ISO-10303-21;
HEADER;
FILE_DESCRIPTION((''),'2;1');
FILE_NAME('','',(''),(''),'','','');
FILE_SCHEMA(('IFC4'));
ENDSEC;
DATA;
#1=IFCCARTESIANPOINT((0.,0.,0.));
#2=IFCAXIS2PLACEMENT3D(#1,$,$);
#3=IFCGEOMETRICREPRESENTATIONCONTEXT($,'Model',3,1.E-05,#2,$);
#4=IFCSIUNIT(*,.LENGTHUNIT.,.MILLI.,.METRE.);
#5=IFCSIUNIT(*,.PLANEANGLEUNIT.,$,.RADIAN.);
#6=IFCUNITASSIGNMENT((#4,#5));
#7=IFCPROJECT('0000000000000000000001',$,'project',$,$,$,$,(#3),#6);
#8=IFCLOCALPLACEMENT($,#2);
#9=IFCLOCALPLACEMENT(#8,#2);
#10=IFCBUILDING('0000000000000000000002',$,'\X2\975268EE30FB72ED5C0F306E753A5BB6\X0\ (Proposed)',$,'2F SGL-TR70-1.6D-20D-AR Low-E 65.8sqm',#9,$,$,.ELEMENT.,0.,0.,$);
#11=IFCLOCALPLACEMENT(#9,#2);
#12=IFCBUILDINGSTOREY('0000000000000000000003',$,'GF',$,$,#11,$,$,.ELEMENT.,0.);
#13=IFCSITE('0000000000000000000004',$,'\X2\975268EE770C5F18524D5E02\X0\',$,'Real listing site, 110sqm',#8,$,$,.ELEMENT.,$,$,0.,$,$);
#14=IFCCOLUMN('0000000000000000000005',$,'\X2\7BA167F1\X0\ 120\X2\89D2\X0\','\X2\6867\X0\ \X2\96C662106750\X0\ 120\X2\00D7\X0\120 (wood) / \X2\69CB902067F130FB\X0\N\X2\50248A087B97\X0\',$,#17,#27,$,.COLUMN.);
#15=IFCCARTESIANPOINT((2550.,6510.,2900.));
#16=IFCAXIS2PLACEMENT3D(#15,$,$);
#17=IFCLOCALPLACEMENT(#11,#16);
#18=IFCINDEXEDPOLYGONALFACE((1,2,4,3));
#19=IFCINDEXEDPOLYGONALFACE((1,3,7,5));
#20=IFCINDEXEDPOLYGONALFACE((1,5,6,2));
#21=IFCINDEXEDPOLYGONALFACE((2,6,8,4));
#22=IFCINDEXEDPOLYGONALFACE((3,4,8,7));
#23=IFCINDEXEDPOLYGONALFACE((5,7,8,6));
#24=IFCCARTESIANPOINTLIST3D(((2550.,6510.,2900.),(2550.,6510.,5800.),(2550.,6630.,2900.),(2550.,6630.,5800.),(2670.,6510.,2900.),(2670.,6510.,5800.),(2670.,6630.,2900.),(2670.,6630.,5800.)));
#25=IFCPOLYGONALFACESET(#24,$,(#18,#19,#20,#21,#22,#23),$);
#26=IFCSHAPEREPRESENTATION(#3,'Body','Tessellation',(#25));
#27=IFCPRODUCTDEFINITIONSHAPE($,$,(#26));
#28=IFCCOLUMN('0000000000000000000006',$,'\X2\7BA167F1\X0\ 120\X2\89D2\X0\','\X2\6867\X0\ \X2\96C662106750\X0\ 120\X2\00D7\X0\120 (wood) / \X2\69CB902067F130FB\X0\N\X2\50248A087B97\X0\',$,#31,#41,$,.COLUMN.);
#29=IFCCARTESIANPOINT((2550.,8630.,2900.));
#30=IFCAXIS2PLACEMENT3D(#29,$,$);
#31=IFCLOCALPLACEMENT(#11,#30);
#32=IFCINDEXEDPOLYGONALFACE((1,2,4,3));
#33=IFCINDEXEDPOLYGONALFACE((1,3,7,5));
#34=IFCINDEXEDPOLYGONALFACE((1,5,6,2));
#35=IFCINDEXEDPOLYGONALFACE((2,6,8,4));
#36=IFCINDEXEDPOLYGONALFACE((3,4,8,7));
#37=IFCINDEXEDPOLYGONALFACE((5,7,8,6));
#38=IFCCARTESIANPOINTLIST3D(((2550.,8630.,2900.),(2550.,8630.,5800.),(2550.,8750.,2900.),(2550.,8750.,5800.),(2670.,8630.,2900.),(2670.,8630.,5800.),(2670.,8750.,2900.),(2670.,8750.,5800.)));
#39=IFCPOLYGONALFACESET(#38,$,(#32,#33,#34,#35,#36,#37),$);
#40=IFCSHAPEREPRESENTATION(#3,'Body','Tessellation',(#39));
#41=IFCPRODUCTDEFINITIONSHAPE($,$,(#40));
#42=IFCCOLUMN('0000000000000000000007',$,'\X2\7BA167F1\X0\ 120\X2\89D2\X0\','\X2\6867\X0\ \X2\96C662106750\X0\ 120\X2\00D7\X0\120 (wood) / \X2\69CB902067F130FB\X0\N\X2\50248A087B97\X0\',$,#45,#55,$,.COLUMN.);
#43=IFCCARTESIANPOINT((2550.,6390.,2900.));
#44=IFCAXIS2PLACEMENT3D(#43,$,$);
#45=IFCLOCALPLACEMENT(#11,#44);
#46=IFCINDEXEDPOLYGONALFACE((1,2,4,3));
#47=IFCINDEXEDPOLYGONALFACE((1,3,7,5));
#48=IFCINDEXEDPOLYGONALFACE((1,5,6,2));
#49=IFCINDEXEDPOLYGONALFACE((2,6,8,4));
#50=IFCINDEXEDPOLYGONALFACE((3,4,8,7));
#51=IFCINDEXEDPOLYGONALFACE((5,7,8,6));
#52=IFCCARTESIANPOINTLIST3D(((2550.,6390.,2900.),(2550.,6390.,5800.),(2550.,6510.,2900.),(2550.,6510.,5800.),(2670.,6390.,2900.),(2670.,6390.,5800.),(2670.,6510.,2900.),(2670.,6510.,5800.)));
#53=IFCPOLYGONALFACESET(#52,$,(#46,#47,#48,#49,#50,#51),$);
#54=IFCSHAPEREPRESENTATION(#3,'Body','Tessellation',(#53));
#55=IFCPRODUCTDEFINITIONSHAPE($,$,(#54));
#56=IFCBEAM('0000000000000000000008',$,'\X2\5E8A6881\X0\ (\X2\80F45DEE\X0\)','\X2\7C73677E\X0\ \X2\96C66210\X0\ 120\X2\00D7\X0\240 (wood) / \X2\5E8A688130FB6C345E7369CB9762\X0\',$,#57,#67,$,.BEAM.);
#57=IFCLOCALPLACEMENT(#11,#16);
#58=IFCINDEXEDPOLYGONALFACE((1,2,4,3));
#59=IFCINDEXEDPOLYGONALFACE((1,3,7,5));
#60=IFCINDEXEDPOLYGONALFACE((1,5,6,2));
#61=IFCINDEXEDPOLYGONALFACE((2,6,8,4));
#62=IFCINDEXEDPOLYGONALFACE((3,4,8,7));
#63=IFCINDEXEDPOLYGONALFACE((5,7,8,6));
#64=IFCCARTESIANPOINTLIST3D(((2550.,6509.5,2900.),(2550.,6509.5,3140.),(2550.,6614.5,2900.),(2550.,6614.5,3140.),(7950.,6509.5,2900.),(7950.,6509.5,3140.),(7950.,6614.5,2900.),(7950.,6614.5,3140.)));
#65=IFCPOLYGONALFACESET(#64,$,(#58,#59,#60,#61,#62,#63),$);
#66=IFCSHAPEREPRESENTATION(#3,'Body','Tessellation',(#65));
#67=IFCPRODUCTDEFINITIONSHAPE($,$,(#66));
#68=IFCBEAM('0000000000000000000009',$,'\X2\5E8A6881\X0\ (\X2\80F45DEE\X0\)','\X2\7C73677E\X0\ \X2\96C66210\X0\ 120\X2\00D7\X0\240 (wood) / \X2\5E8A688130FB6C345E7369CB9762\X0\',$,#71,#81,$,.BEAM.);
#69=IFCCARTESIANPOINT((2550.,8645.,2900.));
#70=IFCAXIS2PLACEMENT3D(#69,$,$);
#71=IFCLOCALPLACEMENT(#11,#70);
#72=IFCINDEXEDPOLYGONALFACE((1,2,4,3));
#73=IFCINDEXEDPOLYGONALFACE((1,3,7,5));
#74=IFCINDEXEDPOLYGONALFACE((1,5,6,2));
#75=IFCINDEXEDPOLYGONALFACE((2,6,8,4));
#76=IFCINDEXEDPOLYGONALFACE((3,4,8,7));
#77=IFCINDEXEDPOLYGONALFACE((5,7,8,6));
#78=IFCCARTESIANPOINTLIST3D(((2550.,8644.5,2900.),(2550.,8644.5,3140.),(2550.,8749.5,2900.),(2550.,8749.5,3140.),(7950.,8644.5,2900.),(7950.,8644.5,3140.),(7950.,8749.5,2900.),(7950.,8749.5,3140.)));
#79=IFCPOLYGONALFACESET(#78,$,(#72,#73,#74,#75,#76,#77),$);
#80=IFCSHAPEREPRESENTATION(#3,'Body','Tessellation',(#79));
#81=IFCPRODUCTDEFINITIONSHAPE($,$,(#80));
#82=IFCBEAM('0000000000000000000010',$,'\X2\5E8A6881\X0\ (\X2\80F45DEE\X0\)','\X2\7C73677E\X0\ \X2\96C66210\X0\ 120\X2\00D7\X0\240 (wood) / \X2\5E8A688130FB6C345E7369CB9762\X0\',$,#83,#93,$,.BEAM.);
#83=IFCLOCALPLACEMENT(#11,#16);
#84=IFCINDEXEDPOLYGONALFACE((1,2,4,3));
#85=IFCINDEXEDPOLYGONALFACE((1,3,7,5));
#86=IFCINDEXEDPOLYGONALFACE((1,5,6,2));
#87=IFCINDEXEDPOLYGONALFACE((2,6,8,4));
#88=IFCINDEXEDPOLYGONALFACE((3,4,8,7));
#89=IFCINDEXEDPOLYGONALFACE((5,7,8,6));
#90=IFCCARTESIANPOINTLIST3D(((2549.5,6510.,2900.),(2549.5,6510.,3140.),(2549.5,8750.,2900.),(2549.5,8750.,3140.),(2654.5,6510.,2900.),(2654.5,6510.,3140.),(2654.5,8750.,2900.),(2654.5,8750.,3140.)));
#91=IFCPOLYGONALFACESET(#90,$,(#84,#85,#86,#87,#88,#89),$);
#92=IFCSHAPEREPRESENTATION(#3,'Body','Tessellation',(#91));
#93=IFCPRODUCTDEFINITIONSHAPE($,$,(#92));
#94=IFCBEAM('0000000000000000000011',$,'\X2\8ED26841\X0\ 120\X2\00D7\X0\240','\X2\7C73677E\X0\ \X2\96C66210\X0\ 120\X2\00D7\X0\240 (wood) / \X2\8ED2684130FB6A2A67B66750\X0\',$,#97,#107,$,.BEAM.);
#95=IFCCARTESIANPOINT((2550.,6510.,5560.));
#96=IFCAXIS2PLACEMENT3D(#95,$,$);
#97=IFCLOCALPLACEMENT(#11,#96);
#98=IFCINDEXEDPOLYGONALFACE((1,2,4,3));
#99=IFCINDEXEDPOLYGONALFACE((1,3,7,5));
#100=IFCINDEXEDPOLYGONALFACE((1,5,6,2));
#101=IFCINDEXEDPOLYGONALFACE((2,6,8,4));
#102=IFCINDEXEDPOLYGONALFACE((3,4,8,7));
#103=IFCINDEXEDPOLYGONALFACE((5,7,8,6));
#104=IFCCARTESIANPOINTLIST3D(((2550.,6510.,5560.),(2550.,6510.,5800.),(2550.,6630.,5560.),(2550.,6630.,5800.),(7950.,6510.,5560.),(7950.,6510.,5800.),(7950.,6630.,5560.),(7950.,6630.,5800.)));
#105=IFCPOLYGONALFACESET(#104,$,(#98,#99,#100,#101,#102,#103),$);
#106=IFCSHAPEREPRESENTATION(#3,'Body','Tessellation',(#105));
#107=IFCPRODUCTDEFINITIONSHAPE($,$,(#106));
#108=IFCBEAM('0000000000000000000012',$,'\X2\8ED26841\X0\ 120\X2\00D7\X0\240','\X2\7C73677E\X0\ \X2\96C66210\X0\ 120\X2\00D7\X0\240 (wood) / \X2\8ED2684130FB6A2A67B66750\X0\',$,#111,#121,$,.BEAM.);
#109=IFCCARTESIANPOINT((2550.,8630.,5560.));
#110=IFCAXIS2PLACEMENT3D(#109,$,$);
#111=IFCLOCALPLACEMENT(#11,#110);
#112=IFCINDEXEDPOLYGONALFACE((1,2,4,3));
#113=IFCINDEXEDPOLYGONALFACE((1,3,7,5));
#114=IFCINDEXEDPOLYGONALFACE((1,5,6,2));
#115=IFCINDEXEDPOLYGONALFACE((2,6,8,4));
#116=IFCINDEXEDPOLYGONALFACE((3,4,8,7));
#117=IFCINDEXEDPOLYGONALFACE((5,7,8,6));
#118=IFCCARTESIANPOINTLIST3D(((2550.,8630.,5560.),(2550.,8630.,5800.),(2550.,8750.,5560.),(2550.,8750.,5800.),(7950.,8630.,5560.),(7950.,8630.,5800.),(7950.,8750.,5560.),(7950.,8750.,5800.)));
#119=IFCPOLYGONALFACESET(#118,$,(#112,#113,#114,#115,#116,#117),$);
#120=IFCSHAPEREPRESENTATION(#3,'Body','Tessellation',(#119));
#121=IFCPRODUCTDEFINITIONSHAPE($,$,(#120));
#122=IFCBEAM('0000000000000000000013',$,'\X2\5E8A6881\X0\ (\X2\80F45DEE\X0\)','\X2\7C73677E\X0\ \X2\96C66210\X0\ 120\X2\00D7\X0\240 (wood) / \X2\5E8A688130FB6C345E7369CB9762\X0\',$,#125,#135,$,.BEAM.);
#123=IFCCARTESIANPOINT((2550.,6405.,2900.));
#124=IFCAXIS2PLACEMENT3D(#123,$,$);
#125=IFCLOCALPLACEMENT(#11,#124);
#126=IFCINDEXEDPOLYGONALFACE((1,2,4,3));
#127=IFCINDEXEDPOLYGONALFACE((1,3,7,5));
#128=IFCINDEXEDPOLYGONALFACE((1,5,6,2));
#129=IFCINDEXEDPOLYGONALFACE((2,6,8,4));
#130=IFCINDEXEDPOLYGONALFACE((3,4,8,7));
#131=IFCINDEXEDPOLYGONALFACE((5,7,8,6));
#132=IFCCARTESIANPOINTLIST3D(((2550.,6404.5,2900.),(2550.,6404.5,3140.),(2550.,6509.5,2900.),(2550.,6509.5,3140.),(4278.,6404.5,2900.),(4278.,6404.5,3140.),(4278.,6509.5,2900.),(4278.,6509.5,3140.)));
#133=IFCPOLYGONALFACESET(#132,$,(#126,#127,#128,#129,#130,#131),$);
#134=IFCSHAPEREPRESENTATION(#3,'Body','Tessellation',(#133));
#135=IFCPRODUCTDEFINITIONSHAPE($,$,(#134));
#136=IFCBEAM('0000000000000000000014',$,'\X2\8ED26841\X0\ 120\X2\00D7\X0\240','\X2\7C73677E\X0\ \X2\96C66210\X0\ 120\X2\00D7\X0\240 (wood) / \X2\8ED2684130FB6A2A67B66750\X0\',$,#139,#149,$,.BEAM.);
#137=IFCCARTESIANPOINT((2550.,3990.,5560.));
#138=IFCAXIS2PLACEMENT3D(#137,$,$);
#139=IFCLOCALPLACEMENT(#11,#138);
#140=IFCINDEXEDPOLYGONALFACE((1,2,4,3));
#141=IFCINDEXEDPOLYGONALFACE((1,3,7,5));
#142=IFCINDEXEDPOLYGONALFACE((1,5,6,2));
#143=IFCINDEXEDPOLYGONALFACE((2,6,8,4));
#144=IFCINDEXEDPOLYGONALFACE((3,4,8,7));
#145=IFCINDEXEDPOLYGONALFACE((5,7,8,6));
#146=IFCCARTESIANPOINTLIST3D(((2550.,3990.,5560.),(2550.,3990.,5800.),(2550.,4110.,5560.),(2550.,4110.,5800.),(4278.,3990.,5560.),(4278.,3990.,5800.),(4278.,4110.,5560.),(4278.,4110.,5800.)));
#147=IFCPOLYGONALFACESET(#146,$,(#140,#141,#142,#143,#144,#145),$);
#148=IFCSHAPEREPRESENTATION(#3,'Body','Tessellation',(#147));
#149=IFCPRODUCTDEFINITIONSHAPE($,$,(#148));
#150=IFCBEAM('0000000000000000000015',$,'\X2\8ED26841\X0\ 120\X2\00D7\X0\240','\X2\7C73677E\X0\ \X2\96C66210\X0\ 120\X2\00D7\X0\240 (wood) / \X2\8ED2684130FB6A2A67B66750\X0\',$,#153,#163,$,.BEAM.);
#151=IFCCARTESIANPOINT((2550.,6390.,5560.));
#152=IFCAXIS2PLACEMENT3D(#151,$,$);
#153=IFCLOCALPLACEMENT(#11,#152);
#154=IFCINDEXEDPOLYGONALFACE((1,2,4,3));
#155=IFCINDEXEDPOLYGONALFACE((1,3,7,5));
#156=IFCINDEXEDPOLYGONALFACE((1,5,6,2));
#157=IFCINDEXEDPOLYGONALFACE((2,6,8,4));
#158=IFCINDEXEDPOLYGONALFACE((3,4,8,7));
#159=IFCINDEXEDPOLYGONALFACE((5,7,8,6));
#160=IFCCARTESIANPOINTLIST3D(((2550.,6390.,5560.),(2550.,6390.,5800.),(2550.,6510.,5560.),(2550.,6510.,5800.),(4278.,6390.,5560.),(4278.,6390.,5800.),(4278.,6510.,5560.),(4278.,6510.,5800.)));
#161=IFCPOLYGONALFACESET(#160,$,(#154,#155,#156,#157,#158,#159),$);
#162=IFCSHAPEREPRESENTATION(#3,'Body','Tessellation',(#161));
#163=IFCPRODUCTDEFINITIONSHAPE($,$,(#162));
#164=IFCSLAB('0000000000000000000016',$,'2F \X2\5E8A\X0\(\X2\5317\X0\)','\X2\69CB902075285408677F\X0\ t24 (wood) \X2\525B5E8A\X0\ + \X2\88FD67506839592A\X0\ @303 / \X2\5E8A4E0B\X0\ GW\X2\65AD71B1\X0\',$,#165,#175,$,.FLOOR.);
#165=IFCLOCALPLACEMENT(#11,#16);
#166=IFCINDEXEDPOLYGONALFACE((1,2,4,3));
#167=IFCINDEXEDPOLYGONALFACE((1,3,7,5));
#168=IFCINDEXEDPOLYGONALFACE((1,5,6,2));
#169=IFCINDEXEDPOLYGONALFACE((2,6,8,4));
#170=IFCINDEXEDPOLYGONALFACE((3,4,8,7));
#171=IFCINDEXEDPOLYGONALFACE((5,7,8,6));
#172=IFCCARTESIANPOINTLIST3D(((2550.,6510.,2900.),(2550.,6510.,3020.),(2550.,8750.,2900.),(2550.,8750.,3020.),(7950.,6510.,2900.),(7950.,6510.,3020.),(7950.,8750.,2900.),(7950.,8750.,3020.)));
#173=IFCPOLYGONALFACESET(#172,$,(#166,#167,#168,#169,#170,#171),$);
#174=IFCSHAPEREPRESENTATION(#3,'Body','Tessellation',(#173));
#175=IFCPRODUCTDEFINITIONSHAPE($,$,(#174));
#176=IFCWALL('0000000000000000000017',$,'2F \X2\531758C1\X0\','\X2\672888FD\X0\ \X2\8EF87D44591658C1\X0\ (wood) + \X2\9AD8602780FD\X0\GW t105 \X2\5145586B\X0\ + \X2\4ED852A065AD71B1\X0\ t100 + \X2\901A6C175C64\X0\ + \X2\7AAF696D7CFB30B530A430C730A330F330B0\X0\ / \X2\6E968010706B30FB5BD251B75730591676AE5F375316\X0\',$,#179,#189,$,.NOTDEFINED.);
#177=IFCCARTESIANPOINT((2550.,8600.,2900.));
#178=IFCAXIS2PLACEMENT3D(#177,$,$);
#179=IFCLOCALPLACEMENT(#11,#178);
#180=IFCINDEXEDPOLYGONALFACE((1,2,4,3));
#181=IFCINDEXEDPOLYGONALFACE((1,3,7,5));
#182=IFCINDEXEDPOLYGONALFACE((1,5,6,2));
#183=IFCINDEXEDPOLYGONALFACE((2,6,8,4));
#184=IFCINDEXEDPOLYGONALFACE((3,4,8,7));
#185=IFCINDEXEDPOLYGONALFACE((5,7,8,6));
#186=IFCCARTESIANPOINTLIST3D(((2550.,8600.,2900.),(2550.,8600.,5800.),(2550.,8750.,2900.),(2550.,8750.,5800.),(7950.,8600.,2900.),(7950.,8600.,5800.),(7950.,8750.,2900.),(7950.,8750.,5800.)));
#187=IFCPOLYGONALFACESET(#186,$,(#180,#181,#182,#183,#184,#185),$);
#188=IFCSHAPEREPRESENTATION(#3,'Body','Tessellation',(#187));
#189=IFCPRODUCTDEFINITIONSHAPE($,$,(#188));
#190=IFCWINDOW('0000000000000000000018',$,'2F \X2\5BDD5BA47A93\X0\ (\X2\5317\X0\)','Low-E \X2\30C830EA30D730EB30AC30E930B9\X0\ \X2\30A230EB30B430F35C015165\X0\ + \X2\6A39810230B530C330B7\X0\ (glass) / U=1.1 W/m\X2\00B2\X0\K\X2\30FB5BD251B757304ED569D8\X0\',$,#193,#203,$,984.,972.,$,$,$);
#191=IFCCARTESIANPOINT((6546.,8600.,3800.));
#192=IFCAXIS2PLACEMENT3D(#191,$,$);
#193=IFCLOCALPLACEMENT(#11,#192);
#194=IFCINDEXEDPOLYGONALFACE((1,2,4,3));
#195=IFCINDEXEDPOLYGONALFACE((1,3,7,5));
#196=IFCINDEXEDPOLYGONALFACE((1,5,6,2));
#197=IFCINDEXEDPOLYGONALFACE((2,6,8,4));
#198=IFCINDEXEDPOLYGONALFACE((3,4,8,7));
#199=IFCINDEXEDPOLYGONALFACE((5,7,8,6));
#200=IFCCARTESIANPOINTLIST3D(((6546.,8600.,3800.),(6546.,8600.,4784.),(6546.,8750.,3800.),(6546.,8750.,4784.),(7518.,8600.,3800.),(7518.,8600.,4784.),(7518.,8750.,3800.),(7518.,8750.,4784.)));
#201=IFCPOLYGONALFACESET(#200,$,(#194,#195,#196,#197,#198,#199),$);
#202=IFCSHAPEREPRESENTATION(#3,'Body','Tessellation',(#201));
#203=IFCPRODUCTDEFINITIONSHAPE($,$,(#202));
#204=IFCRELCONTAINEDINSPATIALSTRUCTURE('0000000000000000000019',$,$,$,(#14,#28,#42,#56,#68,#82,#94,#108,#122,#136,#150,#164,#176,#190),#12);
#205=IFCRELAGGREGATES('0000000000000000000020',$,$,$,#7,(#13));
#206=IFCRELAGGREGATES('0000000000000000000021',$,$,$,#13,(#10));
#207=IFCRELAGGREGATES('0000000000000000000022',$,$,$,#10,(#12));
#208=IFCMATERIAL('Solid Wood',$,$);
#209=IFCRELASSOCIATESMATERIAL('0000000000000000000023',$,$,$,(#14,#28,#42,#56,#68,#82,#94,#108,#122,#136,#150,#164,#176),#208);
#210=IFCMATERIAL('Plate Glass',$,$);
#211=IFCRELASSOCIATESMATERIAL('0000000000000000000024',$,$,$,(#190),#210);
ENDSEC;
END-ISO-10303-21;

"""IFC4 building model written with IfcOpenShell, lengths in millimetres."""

from ifc_helpers import new_model, si_unit, frame, frame_2d, origin, place, context, project, spatial, rectangle, extrude, material, element, fill, save


model = new_model("IFC4")

# Units and contexts
model_context = context("Model", 3, precision=1e-05, world=origin())
ifc_project = project(units=[si_unit("LENGTHUNIT", "METRE", prefix="MILLI"), si_unit("PLANEANGLEUNIT", "RADIAN")], contexts=[model_context])

# Site, building, storey
site_placement = place(None, origin())
site = spatial("IfcSite", under=ifc_project, at=site_placement, Name="青森県弘前市", ObjectType="Real listing site, 110sqm", CompositionType="ELEMENT", RefElevation=0.0)
building_placement = place(site_placement, origin())
building = spatial("IfcBuilding", under=site, at=building_placement, Name="青森・狭小の町家 (Proposed)", ObjectType="2F SGL-TR70-1.6D-20D-AR Low-E 65.8sqm", CompositionType="ELEMENT", ElevationOfRefHeight=0.0, ElevationOfTerrain=0.0)
storey_placement = place(building_placement, origin())
storey = spatial("IfcBuildingStorey", under=building, at=storey_placement, Name="GF", CompositionType="ELEMENT", Elevation=0.0)

# Columns
ifc_material_1 = material(Name="Solid Wood")
column_1_placement = place(storey_placement, frame((2550.0, 6510.0, 2900.0)))
element("IfcColumn", 1, at=column_1_placement, inside=storey, material=ifc_material_1, Name="管柱 120角", Description="桧 集成材 120×120 (wood) / 構造柱・N値計算", PredefinedType="COLUMN", context=model_context, shape_type="SweptSolid", body=[
    extrude(rectangle(XDim=120.0, YDim=120.0, at=frame_2d((60.0, 60.0))), frame((2550.0, 6510.0, 2900.0)), (0.0, 0.0, 1.0), 2900.0),
])
column_2_placement = place(storey_placement, frame((2550.0, 8630.0, 2900.0)))
element("IfcColumn", 2, at=column_2_placement, inside=storey, material=ifc_material_1, Name="管柱 120角", Description="桧 集成材 120×120 (wood) / 構造柱・N値計算", PredefinedType="COLUMN", context=model_context, shape_type="SweptSolid", body=[
    extrude(rectangle(XDim=120.0, YDim=120.0, at=frame_2d((60.0, 60.0))), frame((2550.0, 8630.0, 2900.0)), (0.0, 0.0, 1.0), 2900.0),
])
column_3_placement = place(storey_placement, frame((2550.0, 6390.0, 2900.0)))
element("IfcColumn", 3, at=column_3_placement, inside=storey, material=ifc_material_1, Name="管柱 120角", Description="桧 集成材 120×120 (wood) / 構造柱・N値計算", PredefinedType="COLUMN", context=model_context, shape_type="SweptSolid", body=[
    extrude(rectangle(XDim=120.0, YDim=120.0, at=frame_2d((60.0, 60.0))), frame((2550.0, 6390.0, 2900.0)), (0.0, 0.0, 1.0), 2900.0),
])

# Beams
beam_1_placement = place(storey_placement, frame((2550.0, 6510.0, 2900.0)))
element("IfcBeam", 4, at=beam_1_placement, inside=storey, material=ifc_material_1, Name="床梁 (胴差)", Description="米松 集成 120×240 (wood) / 床梁・水平構面", PredefinedType="BEAM", context=model_context, shape_type="SweptSolid", body=[
    extrude(rectangle(XDim=5400.0, YDim=105.0, at=frame_2d((2700.0, 52.0))), frame((2550.0, 6510.0, 2900.0)), (0.0, 0.0, 1.0), 240.0),
])
beam_2_placement = place(storey_placement, frame((2550.0, 8645.0, 2900.0)))
element("IfcBeam", 5, at=beam_2_placement, inside=storey, material=ifc_material_1, Name="床梁 (胴差)", Description="米松 集成 120×240 (wood) / 床梁・水平構面", PredefinedType="BEAM", context=model_context, shape_type="SweptSolid", body=[
    extrude(rectangle(XDim=5400.0, YDim=105.0, at=frame_2d((2700.0, 52.0))), frame((2550.0, 8645.0, 2900.0)), (0.0, 0.0, 1.0), 240.0),
])
beam_3_placement = place(storey_placement, frame((2550.0, 6510.0, 2900.0)))
element("IfcBeam", 6, at=beam_3_placement, inside=storey, material=ifc_material_1, Name="床梁 (胴差)", Description="米松 集成 120×240 (wood) / 床梁・水平構面", PredefinedType="BEAM", context=model_context, shape_type="SweptSolid", body=[
    extrude(rectangle(XDim=105.0, YDim=2240.0, at=frame_2d((52.0, 1120.0))), frame((2550.0, 6510.0, 2900.0)), (0.0, 0.0, 1.0), 240.0),
])
beam_4_placement = place(storey_placement, frame((2550.0, 6510.0, 5560.0)))
element("IfcBeam", 7, at=beam_4_placement, inside=storey, material=ifc_material_1, Name="軒桁 120×240", Description="米松 集成 120×240 (wood) / 軒桁・横架材", PredefinedType="BEAM", context=model_context, shape_type="SweptSolid", body=[
    extrude(rectangle(XDim=5400.0, YDim=120.0, at=frame_2d((2700.0, 60.0))), frame((2550.0, 6510.0, 5560.0)), (0.0, 0.0, 1.0), 240.0),
])
beam_5_placement = place(storey_placement, frame((2550.0, 8630.0, 5560.0)))
element("IfcBeam", 8, at=beam_5_placement, inside=storey, material=ifc_material_1, Name="軒桁 120×240", Description="米松 集成 120×240 (wood) / 軒桁・横架材", PredefinedType="BEAM", context=model_context, shape_type="SweptSolid", body=[
    extrude(rectangle(XDim=5400.0, YDim=120.0, at=frame_2d((2700.0, 60.0))), frame((2550.0, 8630.0, 5560.0)), (0.0, 0.0, 1.0), 240.0),
])
beam_6_placement = place(storey_placement, frame((2550.0, 6405.0, 2900.0)))
element("IfcBeam", 9, at=beam_6_placement, inside=storey, material=ifc_material_1, Name="床梁 (胴差)", Description="米松 集成 120×240 (wood) / 床梁・水平構面", PredefinedType="BEAM", context=model_context, shape_type="SweptSolid", body=[
    extrude(rectangle(XDim=1728.0, YDim=105.0, at=frame_2d((864.0, 52.0))), frame((2550.0, 6405.0, 2900.0)), (0.0, 0.0, 1.0), 240.0),
])
beam_7_placement = place(storey_placement, frame((2550.0, 3990.0, 5560.0)))
element("IfcBeam", 10, at=beam_7_placement, inside=storey, material=ifc_material_1, Name="軒桁 120×240", Description="米松 集成 120×240 (wood) / 軒桁・横架材", PredefinedType="BEAM", context=model_context, shape_type="SweptSolid", body=[
    extrude(rectangle(XDim=1728.0, YDim=120.0, at=frame_2d((864.0, 60.0))), frame((2550.0, 3990.0, 5560.0)), (0.0, 0.0, 1.0), 240.0),
])
beam_8_placement = place(storey_placement, frame((2550.0, 6390.0, 5560.0)))
element("IfcBeam", 11, at=beam_8_placement, inside=storey, material=ifc_material_1, Name="軒桁 120×240", Description="米松 集成 120×240 (wood) / 軒桁・横架材", PredefinedType="BEAM", context=model_context, shape_type="SweptSolid", body=[
    extrude(rectangle(XDim=1728.0, YDim=120.0, at=frame_2d((864.0, 60.0))), frame((2550.0, 6390.0, 5560.0)), (0.0, 0.0, 1.0), 240.0),
])

# Slab
slab_placement = place(storey_placement, frame((2550.0, 6510.0, 2900.0)))
element("IfcSlab", 12, at=slab_placement, inside=storey, material=ifc_material_1, Name="2F 床(北)", Description="構造用合板 t24 (wood) 剛床 + 製材根太 @303 / 床下 GW断熱", PredefinedType="FLOOR", context=model_context, shape_type="SweptSolid", body=[
    extrude(rectangle(XDim=5400.0, YDim=2240.0, at=frame_2d((2700.0, 1120.0))), frame((2550.0, 6510.0, 2900.0)), (0.0, 0.0, 1.0), 120.0),
])

# Wall, opening, window
wall_placement = place(storey_placement, frame((2550.0, 8600.0, 2900.0)))
wall = element("IfcWall", 13, at=wall_placement, inside=storey, material=ifc_material_1, Name="2F 北壁", Description="木製 軸組外壁 (wood) + 高性能GW t105 充填 + 付加断熱 t100 + 通気層 + 窯業系サイディング / 準耐火・寒冷地外皮強化", PredefinedType="NOTDEFINED", context=model_context, shape_type="SweptSolid", body=[
    extrude(rectangle(XDim=5400.0, YDim=150.0, at=frame_2d((2700.0, 75.0))), frame((2550.0, 8600.0, 2900.0)), (0.0, 0.0, 1.0), 2900.0),
])
opening_placement = place(storey_placement, frame((6546.0, 8600.0, 3800.0)))
opening = element("IfcOpeningElement", 14, at=opening_placement, cuts=wall, PredefinedType="NOTDEFINED", context=model_context, shape_type="SweptSolid", body=[
    extrude(rectangle(XDim=972.0, YDim=150.0, at=frame_2d((486.0, 75.0))), frame((6546.0, 8600.0, 3800.0)), (0.0, 0.0, 1.0), 984.0),
])
ifc_material_2 = material(Name="Plate Glass")
window_placement = place(storey_placement, frame((6546.0, 8600.0, 3800.0)))
window = element("IfcWindow", 15, at=window_placement, inside=storey, material=ifc_material_2, Name="2F 寝室窓 (北)", Description="Low-E トリプルガラス アルゴン封入 + 樹脂サッシ (glass) / U=1.1 W/m²K・寒冷地仕様", OverallHeight=984.0, OverallWidth=972.0, context=model_context, shape_type="SweptSolid", body=[
    extrude(rectangle(XDim=972.0, YDim=150.0, at=frame_2d((486.0, 75.0))), frame((6546.0, 8600.0, 3800.0)), (0.0, 0.0, 1.0), 984.0),
])
fill(opening, window)

save(model, "model.ifc")
